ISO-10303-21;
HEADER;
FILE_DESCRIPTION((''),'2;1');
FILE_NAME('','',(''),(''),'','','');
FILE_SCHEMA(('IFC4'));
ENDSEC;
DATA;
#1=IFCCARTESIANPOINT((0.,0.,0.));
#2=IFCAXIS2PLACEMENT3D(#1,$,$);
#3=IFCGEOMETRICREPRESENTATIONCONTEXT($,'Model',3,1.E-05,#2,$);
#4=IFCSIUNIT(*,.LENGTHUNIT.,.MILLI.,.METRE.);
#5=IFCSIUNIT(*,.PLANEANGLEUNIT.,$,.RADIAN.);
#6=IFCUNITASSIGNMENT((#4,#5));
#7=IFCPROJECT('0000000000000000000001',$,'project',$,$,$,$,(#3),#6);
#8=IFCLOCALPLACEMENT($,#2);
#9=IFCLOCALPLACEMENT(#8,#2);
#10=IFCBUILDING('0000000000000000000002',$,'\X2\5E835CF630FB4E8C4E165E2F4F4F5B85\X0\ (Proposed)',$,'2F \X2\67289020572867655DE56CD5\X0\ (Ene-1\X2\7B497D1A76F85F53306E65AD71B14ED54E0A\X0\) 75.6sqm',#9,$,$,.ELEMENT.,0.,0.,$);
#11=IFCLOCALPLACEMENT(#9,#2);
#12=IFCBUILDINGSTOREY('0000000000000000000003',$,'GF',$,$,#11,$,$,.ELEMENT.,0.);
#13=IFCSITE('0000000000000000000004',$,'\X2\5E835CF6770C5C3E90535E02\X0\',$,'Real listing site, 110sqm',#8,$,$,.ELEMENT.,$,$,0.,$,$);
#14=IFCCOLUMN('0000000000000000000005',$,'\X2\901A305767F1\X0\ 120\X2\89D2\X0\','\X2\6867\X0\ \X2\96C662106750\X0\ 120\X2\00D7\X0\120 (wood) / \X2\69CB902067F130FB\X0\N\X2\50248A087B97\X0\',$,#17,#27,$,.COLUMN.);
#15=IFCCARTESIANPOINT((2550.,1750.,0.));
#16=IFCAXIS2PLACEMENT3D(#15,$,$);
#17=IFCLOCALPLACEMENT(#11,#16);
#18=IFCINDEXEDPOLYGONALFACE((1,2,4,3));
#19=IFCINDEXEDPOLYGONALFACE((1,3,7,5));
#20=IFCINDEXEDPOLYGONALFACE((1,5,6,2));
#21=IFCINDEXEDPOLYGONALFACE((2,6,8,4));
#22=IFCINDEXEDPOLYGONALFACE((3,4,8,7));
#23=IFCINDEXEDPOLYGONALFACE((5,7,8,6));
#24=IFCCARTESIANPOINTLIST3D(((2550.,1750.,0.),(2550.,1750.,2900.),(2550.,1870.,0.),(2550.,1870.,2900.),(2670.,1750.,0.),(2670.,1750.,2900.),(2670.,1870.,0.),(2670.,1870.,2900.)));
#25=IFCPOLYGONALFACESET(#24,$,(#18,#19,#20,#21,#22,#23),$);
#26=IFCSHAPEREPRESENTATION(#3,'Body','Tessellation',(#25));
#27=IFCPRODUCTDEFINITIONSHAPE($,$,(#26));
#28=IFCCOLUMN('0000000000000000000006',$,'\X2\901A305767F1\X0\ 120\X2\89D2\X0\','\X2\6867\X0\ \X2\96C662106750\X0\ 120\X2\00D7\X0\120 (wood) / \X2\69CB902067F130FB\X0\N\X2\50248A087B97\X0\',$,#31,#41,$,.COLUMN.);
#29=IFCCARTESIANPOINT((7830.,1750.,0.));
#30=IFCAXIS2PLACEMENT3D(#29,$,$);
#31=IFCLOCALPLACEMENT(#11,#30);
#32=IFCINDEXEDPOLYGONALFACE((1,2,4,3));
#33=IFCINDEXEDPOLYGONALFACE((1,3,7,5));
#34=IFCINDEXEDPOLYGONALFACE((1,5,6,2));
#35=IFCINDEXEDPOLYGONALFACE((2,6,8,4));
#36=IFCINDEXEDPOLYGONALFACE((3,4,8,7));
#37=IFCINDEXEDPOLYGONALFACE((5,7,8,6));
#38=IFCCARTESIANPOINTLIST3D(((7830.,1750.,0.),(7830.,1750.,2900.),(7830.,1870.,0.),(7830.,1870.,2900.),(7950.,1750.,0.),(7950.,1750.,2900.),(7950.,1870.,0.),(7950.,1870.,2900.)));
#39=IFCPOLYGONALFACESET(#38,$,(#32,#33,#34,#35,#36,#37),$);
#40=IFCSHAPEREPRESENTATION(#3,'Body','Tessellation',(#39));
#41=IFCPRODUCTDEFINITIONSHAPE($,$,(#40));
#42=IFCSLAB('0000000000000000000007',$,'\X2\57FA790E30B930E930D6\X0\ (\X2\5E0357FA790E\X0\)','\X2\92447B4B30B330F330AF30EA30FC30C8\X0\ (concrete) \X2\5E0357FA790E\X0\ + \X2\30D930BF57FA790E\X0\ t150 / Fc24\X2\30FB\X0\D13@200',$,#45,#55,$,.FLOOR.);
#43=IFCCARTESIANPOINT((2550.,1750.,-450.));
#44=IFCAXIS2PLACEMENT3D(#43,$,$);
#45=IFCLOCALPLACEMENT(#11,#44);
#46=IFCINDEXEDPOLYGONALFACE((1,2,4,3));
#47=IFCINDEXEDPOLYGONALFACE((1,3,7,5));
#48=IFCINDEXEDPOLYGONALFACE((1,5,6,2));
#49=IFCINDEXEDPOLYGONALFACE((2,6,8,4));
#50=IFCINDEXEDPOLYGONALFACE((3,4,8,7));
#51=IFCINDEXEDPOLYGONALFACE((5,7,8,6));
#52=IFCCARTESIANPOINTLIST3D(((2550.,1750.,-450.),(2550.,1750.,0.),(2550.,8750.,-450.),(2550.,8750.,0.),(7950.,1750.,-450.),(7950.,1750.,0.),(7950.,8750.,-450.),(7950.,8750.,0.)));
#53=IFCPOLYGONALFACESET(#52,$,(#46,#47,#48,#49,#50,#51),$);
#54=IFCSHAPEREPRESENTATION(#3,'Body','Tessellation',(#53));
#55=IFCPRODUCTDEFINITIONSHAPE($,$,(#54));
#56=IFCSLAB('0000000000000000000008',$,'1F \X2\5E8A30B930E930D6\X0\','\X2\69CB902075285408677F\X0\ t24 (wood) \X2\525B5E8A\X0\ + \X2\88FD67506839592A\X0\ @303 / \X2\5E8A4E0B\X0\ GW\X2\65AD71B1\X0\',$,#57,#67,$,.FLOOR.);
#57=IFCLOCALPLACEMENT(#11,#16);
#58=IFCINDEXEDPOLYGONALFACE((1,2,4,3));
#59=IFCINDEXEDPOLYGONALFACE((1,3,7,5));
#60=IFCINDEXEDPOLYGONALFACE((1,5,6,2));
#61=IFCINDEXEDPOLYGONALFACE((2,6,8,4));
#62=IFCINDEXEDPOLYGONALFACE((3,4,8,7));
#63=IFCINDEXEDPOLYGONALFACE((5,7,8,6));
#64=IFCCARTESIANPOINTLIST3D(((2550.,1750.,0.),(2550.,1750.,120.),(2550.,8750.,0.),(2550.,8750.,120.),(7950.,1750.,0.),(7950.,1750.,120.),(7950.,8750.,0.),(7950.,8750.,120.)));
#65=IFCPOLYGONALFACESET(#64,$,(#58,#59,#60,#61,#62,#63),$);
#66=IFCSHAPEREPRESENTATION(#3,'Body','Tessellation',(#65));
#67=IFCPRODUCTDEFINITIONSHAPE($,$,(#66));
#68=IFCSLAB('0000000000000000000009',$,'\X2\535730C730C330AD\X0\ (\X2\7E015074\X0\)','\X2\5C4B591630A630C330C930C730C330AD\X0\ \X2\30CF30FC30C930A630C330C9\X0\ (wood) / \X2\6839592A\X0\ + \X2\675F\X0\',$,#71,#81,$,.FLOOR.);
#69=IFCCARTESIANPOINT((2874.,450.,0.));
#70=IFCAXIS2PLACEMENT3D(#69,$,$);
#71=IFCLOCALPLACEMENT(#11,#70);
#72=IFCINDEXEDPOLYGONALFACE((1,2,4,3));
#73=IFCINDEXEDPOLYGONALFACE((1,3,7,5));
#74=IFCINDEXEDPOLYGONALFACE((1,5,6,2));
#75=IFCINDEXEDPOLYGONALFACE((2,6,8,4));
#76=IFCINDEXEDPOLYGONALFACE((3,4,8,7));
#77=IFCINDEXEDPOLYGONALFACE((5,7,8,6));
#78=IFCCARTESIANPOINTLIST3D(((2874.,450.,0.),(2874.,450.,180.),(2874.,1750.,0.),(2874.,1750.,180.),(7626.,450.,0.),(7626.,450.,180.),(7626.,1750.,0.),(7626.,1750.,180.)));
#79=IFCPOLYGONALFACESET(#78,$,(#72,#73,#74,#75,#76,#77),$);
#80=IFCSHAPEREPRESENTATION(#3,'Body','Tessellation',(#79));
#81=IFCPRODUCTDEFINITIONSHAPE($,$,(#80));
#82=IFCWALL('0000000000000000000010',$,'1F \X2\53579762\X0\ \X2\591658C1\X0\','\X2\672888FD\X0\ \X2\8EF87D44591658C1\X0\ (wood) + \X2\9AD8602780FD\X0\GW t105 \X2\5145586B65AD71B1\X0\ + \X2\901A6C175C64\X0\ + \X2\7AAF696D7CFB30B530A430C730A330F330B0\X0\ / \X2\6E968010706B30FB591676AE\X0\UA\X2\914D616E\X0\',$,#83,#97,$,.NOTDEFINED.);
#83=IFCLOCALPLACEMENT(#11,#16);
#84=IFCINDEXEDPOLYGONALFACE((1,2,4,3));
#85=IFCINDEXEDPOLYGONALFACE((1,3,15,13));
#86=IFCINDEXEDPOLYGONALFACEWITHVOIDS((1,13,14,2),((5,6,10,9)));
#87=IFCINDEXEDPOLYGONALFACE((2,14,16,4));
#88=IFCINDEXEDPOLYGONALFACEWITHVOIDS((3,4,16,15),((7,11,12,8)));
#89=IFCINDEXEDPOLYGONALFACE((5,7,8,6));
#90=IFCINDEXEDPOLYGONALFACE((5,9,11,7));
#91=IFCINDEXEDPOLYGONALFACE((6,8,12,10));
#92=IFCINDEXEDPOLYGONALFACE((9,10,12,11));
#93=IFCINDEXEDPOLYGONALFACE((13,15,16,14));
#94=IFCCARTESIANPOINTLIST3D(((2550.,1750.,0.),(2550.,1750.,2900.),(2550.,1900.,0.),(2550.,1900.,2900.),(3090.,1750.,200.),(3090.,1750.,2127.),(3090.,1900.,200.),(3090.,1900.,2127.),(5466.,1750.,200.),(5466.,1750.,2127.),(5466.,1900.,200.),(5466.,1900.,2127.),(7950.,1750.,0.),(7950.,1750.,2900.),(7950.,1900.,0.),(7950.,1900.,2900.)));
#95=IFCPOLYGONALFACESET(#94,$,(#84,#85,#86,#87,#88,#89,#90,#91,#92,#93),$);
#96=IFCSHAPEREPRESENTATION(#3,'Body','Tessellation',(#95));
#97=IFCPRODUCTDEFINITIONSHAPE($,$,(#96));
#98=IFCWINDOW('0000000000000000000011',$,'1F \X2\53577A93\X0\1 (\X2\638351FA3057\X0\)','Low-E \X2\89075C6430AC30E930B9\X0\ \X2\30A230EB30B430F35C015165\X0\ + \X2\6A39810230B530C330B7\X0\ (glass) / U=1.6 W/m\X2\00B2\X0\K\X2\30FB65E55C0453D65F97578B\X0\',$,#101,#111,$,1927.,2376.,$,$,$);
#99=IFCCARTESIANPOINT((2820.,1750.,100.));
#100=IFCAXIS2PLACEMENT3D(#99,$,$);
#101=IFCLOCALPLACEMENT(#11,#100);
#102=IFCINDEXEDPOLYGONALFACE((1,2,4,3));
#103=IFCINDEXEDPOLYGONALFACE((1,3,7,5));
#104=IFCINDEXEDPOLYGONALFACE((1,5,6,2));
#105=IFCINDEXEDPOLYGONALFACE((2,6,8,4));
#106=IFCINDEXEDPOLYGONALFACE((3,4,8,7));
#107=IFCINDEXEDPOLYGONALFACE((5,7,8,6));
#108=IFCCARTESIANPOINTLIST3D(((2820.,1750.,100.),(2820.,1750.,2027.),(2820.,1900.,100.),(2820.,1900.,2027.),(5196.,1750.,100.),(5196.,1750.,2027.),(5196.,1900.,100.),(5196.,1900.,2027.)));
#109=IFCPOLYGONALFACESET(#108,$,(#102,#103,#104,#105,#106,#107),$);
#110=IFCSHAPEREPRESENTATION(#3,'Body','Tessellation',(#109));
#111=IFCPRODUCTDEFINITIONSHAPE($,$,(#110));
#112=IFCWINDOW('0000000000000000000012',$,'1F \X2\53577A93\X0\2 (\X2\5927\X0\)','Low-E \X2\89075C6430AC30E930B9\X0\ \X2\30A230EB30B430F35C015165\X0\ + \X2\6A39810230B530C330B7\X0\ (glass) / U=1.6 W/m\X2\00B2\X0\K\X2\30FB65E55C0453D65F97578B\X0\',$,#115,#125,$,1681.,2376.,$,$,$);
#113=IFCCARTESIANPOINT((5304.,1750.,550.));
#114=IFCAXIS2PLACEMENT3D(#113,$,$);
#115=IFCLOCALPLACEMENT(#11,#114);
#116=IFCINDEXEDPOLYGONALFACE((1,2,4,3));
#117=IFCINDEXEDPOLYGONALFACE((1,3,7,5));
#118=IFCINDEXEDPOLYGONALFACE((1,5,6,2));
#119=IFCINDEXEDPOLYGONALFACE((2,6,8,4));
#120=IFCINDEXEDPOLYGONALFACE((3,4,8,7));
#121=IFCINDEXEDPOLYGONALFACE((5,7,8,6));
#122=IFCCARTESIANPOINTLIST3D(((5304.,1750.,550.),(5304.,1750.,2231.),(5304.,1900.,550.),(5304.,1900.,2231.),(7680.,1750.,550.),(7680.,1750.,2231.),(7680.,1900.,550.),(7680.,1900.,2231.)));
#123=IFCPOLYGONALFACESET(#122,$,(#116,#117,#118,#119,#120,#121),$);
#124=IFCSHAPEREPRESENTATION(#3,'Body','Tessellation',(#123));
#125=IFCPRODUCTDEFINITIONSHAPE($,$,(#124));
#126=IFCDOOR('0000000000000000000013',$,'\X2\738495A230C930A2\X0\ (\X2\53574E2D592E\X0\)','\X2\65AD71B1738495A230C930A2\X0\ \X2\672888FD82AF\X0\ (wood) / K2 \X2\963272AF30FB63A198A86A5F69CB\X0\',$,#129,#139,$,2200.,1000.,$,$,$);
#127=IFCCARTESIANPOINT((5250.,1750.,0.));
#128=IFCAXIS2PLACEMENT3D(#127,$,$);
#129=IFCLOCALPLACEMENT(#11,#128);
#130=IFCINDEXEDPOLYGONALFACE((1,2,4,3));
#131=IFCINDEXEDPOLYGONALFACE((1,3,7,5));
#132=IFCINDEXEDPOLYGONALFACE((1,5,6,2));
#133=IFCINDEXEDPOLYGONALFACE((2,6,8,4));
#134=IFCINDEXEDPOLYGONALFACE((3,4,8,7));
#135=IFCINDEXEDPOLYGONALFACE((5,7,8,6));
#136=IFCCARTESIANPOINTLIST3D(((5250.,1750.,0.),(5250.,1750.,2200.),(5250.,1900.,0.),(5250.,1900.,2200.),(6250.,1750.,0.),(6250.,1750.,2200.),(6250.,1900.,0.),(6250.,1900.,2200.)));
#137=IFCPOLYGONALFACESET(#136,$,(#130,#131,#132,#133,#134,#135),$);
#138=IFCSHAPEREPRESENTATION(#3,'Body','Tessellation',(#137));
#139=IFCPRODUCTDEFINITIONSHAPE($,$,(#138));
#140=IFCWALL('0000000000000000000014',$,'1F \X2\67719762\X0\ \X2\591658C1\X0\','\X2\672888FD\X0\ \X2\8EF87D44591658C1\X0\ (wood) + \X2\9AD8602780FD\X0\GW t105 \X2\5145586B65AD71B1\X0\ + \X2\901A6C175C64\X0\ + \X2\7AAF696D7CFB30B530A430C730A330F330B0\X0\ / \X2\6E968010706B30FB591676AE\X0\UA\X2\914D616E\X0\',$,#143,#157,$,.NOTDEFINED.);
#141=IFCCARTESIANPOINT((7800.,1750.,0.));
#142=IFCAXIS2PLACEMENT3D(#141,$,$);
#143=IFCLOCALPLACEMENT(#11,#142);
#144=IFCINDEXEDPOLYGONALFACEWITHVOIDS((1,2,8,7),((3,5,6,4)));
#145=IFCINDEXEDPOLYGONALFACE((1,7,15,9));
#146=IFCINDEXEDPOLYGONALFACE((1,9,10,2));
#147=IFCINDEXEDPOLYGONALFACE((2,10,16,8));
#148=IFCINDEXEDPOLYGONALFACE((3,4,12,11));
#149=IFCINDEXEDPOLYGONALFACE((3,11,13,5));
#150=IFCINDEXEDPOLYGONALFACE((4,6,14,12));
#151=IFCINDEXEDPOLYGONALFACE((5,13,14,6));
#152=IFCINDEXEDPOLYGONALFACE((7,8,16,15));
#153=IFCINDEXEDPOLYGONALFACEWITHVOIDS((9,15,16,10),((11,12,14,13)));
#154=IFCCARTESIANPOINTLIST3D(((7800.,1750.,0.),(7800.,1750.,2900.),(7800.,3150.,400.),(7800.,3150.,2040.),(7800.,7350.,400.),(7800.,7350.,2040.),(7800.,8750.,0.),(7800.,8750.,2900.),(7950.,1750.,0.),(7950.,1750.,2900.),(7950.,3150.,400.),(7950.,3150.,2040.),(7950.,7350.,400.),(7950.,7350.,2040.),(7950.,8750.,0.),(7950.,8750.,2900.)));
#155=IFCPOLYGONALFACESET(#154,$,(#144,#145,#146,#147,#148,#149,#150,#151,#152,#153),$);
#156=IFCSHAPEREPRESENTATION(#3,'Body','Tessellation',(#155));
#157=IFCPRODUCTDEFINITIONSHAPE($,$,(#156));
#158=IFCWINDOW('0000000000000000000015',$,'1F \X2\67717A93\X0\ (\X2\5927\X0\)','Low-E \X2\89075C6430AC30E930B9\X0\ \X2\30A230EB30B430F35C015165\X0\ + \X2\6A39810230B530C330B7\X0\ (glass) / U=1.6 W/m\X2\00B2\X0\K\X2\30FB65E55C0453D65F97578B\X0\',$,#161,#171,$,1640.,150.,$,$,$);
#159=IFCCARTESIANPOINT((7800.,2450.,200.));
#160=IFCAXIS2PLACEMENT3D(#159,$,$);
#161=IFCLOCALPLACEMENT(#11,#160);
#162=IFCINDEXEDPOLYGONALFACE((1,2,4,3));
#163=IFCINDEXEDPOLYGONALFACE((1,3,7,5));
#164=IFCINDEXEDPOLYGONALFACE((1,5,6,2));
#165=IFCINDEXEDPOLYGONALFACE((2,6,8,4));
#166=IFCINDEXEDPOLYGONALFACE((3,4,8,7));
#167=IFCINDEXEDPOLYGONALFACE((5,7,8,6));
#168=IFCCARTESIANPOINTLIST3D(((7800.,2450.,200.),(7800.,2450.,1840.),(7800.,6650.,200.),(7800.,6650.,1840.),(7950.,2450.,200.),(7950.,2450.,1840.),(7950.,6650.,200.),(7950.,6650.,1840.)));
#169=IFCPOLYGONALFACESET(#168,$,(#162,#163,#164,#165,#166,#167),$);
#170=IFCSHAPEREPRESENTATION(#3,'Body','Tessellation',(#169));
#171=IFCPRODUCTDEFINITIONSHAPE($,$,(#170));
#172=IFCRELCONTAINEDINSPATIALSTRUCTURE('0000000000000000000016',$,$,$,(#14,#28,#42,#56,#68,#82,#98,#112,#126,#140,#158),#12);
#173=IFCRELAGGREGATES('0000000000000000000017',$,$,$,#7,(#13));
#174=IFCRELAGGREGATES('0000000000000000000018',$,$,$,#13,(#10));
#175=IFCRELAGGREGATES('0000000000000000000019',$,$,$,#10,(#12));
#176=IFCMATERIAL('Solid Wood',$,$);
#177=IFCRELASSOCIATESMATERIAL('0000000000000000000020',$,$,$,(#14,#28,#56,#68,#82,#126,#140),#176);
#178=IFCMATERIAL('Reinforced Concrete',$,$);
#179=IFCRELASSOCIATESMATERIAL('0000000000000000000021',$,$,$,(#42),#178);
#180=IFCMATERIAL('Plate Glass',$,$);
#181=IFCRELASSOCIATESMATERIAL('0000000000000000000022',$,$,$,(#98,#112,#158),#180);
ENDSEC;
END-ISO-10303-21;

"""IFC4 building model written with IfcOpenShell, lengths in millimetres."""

from ifc_helpers import new_model, si_unit, frame, frame_2d, origin, place, context, project, spatial, rectangle, extrude, material, element, fill, save


model = new_model("IFC4")

# Units and contexts
model_context = context("Model", 3, precision=1e-05, world=origin())
ifc_project = project(units=[si_unit("LENGTHUNIT", "METRE", prefix="MILLI"), si_unit("PLANEANGLEUNIT", "RADIAN")], contexts=[model_context])

# Site, building, storey
site_placement = place(None, origin())
site = spatial("IfcSite", under=ifc_project, at=site_placement, Name="広島県尾道市", ObjectType="Real listing site, 110sqm", CompositionType="ELEMENT", RefElevation=0.0)
building_placement = place(site_placement, origin())
building = spatial("IfcBuilding", under=site, at=building_placement, Name="広島・二世帯住宅 (Proposed)", ObjectType="2F 木造在来工法 (Ene-1等級相当の断熱仕上) 75.6sqm", CompositionType="ELEMENT", ElevationOfRefHeight=0.0, ElevationOfTerrain=0.0)
storey_placement = place(building_placement, origin())
storey = spatial("IfcBuildingStorey", under=building, at=storey_placement, Name="GF", CompositionType="ELEMENT", Elevation=0.0)

# Columns
ifc_material_1 = material(Name="Solid Wood")
column_1_placement = place(storey_placement, frame((2550.0, 1750.0, 0.0)))
element("IfcColumn", 1, at=column_1_placement, inside=storey, material=ifc_material_1, Name="通し柱 120角", Description="桧 集成材 120×120 (wood) / 構造柱・N値計算", PredefinedType="COLUMN", context=model_context, shape_type="SweptSolid", body=[
    extrude(rectangle(XDim=120.0, YDim=120.0, at=frame_2d((60.0, 60.0))), frame((2550.0, 1750.0, 0.0)), (0.0, 0.0, 1.0), 2900.0),
])
column_2_placement = place(storey_placement, frame((7830.0, 1750.0, 0.0)))
element("IfcColumn", 2, at=column_2_placement, inside=storey, material=ifc_material_1, Name="通し柱 120角", Description="桧 集成材 120×120 (wood) / 構造柱・N値計算", PredefinedType="COLUMN", context=model_context, shape_type="SweptSolid", body=[
    extrude(rectangle(XDim=120.0, YDim=120.0, at=frame_2d((60.0, 60.0))), frame((7830.0, 1750.0, 0.0)), (0.0, 0.0, 1.0), 2900.0),
])

# Slabs
ifc_material_2 = material(Name="Reinforced Concrete")
slab_1_placement = place(storey_placement, frame((2550.0, 1750.0, -450.0)))
element("IfcSlab", 3, at=slab_1_placement, inside=storey, material=ifc_material_2, Name="基礎スラブ (布基礎)", Description="鉄筋コンクリート (concrete) 布基礎 + ベタ基礎 t150 / Fc24・D13@200", PredefinedType="FLOOR", context=model_context, shape_type="SweptSolid", body=[
    extrude(rectangle(XDim=5400.0, YDim=7000.0, at=frame_2d((2700.0, 3500.0))), frame((2550.0, 1750.0, -450.0)), (0.0, 0.0, 1.0), 450.0),
])
slab_2_placement = place(storey_placement, frame((2550.0, 1750.0, 0.0)))
element("IfcSlab", 4, at=slab_2_placement, inside=storey, material=ifc_material_1, Name="1F 床スラブ", Description="構造用合板 t24 (wood) 剛床 + 製材根太 @303 / 床下 GW断熱", PredefinedType="FLOOR", context=model_context, shape_type="SweptSolid", body=[
    extrude(rectangle(XDim=5400.0, YDim=7000.0, at=frame_2d((2700.0, 3500.0))), frame((2550.0, 1750.0, 0.0)), (0.0, 0.0, 1.0), 120.0),
])
slab_3_placement = place(storey_placement, frame((2874.0, 450.0, 0.0)))
element("IfcSlab", 5, at=slab_3_placement, inside=storey, material=ifc_material_1, Name="南デッキ (縁側)", Description="屋外ウッドデッキ ハードウッド (wood) / 根太 + 束", PredefinedType="FLOOR", context=model_context, shape_type="SweptSolid", body=[
    extrude(rectangle(XDim=4752.0, YDim=1300.0, at=frame_2d((2376.0, 650.0))), frame((2874.0, 450.0, 0.0)), (0.0, 0.0, 1.0), 180.0),
])

# Wall, openings, windows, door
wall_1_placement = place(storey_placement, frame((2550.0, 1750.0, 0.0)))
wall_1 = element("IfcWall", 6, at=wall_1_placement, inside=storey, material=ifc_material_1, Name="1F 南面 外壁", Description="木製 軸組外壁 (wood) + 高性能GW t105 充填断熱 + 通気層 + 窯業系サイディング / 準耐火・外皮UA配慮", PredefinedType="NOTDEFINED", context=model_context, shape_type="SweptSolid", body=[
    extrude(rectangle(XDim=5400.0, YDim=150.0, at=frame_2d((2700.0, 75.0))), frame((2550.0, 1750.0, 0.0)), (0.0, 0.0, 1.0), 2900.0),
])
opening_1_placement = place(storey_placement, frame((2820.0, 1750.0, 100.0)))
opening_1 = element("IfcOpeningElement", 7, at=opening_1_placement, cuts=wall_1, PredefinedType="NOTDEFINED", context=model_context, shape_type="SweptSolid", body=[
    extrude(rectangle(XDim=2376.0, YDim=150.0, at=frame_2d((1188.0, 75.0))), frame((2820.0, 1750.0, 100.0)), (0.0, 0.0, 1.0), 1927.0),
])
opening_2_placement = place(storey_placement, frame((5304.0, 1750.0, 550.0)))
opening_2 = element("IfcOpeningElement", 8, at=opening_2_placement, cuts=wall_1, PredefinedType="NOTDEFINED", context=model_context, shape_type="SweptSolid", body=[
    extrude(rectangle(XDim=2376.0, YDim=150.0, at=frame_2d((1188.0, 75.0))), frame((5304.0, 1750.0, 550.0)), (0.0, 0.0, 1.0), 1681.0),
])
opening_3_placement = place(storey_placement, frame((5250.0, 1750.0, 0.0)))
opening_3 = element("IfcOpeningElement", 9, at=opening_3_placement, cuts=wall_1, PredefinedType="NOTDEFINED", context=model_context, shape_type="SweptSolid", body=[
    extrude(rectangle(XDim=1000.0, YDim=150.0, at=frame_2d((500.0, 75.0))), frame((5250.0, 1750.0, 0.0)), (0.0, 0.0, 1.0), 2200.0),
])
ifc_material_3 = material(Name="Plate Glass")
window_1_placement = place(storey_placement, frame((2820.0, 1750.0, 100.0)))
window_1 = element("IfcWindow", 10, at=window_1_placement, inside=storey, material=ifc_material_3, Name="1F 南窓1 (掃出し)", Description="Low-E 複層ガラス アルゴン封入 + 樹脂サッシ (glass) / U=1.6 W/m²K・日射取得型", OverallHeight=1927.0, OverallWidth=2376.0, context=model_context, shape_type="SweptSolid", body=[
    extrude(rectangle(XDim=2376.0, YDim=150.0, at=frame_2d((1188.0, 75.0))), frame((2820.0, 1750.0, 100.0)), (0.0, 0.0, 1.0), 1927.0),
])
fill(opening_1, window_1)
window_2_placement = place(storey_placement, frame((5304.0, 1750.0, 550.0)))
window_2 = element("IfcWindow", 11, at=window_2_placement, inside=storey, material=ifc_material_3, Name="1F 南窓2 (大)", Description="Low-E 複層ガラス アルゴン封入 + 樹脂サッシ (glass) / U=1.6 W/m²K・日射取得型", OverallHeight=1681.0, OverallWidth=2376.0, context=model_context, shape_type="SweptSolid", body=[
    extrude(rectangle(XDim=2376.0, YDim=150.0, at=frame_2d((1188.0, 75.0))), frame((5304.0, 1750.0, 550.0)), (0.0, 0.0, 1.0), 1681.0),
])
fill(opening_2, window_2)
door_placement = place(storey_placement, frame((5250.0, 1750.0, 0.0)))
door = element("IfcDoor", 12, at=door_placement, inside=storey, material=ifc_material_1, Name="玄関ドア (南中央)", Description="断熱玄関ドア 木製芯 (wood) / K2 防犯・採風機構", OverallHeight=2200.0, OverallWidth=1000.0, context=model_context, shape_type="SweptSolid", body=[
    extrude(rectangle(XDim=1000.0, YDim=150.0, at=frame_2d((500.0, 75.0))), frame((5250.0, 1750.0, 0.0)), (0.0, 0.0, 1.0), 2200.0),
])
fill(opening_3, door)

# Wall, opening, window
wall_2_placement = place(storey_placement, frame((7800.0, 1750.0, 0.0)))
wall_2 = element("IfcWall", 13, at=wall_2_placement, inside=storey, material=ifc_material_1, Name="1F 東面 外壁", Description="木製 軸組外壁 (wood) + 高性能GW t105 充填断熱 + 通気層 + 窯業系サイディング / 準耐火・外皮UA配慮", PredefinedType="NOTDEFINED", context=model_context, shape_type="SweptSolid", body=[
    extrude(rectangle(XDim=150.0, YDim=7000.0, at=frame_2d((75.0, 3500.0))), frame((7800.0, 1750.0, 0.0)), (0.0, 0.0, 1.0), 2900.0),
])
opening_4_placement = place(storey_placement, frame((7800.0, 2450.0, 200.0)))
opening_4 = element("IfcOpeningElement", 14, at=opening_4_placement, cuts=wall_2, PredefinedType="NOTDEFINED", context=model_context, shape_type="SweptSolid", body=[
    extrude(rectangle(XDim=150.0, YDim=4200.0, at=frame_2d((75.0, 2100.0))), frame((7800.0, 2450.0, 200.0)), (0.0, 0.0, 1.0), 1640.0),
])
window_3_placement = place(storey_placement, frame((7800.0, 2450.0, 200.0)))
window_3 = element("IfcWindow", 15, at=window_3_placement, inside=storey, material=ifc_material_3, Name="1F 東窓 (大)", Description="Low-E 複層ガラス アルゴン封入 + 樹脂サッシ (glass) / U=1.6 W/m²K・日射取得型", OverallHeight=1640.0, OverallWidth=150.0, context=model_context, shape_type="SweptSolid", body=[
    extrude(rectangle(XDim=150.0, YDim=4200.0, at=frame_2d((75.0, 2100.0))), frame((7800.0, 2450.0, 200.0)), (0.0, 0.0, 1.0), 1640.0),
])
fill(opening_4, window_3)

save(model, "model.ifc")
